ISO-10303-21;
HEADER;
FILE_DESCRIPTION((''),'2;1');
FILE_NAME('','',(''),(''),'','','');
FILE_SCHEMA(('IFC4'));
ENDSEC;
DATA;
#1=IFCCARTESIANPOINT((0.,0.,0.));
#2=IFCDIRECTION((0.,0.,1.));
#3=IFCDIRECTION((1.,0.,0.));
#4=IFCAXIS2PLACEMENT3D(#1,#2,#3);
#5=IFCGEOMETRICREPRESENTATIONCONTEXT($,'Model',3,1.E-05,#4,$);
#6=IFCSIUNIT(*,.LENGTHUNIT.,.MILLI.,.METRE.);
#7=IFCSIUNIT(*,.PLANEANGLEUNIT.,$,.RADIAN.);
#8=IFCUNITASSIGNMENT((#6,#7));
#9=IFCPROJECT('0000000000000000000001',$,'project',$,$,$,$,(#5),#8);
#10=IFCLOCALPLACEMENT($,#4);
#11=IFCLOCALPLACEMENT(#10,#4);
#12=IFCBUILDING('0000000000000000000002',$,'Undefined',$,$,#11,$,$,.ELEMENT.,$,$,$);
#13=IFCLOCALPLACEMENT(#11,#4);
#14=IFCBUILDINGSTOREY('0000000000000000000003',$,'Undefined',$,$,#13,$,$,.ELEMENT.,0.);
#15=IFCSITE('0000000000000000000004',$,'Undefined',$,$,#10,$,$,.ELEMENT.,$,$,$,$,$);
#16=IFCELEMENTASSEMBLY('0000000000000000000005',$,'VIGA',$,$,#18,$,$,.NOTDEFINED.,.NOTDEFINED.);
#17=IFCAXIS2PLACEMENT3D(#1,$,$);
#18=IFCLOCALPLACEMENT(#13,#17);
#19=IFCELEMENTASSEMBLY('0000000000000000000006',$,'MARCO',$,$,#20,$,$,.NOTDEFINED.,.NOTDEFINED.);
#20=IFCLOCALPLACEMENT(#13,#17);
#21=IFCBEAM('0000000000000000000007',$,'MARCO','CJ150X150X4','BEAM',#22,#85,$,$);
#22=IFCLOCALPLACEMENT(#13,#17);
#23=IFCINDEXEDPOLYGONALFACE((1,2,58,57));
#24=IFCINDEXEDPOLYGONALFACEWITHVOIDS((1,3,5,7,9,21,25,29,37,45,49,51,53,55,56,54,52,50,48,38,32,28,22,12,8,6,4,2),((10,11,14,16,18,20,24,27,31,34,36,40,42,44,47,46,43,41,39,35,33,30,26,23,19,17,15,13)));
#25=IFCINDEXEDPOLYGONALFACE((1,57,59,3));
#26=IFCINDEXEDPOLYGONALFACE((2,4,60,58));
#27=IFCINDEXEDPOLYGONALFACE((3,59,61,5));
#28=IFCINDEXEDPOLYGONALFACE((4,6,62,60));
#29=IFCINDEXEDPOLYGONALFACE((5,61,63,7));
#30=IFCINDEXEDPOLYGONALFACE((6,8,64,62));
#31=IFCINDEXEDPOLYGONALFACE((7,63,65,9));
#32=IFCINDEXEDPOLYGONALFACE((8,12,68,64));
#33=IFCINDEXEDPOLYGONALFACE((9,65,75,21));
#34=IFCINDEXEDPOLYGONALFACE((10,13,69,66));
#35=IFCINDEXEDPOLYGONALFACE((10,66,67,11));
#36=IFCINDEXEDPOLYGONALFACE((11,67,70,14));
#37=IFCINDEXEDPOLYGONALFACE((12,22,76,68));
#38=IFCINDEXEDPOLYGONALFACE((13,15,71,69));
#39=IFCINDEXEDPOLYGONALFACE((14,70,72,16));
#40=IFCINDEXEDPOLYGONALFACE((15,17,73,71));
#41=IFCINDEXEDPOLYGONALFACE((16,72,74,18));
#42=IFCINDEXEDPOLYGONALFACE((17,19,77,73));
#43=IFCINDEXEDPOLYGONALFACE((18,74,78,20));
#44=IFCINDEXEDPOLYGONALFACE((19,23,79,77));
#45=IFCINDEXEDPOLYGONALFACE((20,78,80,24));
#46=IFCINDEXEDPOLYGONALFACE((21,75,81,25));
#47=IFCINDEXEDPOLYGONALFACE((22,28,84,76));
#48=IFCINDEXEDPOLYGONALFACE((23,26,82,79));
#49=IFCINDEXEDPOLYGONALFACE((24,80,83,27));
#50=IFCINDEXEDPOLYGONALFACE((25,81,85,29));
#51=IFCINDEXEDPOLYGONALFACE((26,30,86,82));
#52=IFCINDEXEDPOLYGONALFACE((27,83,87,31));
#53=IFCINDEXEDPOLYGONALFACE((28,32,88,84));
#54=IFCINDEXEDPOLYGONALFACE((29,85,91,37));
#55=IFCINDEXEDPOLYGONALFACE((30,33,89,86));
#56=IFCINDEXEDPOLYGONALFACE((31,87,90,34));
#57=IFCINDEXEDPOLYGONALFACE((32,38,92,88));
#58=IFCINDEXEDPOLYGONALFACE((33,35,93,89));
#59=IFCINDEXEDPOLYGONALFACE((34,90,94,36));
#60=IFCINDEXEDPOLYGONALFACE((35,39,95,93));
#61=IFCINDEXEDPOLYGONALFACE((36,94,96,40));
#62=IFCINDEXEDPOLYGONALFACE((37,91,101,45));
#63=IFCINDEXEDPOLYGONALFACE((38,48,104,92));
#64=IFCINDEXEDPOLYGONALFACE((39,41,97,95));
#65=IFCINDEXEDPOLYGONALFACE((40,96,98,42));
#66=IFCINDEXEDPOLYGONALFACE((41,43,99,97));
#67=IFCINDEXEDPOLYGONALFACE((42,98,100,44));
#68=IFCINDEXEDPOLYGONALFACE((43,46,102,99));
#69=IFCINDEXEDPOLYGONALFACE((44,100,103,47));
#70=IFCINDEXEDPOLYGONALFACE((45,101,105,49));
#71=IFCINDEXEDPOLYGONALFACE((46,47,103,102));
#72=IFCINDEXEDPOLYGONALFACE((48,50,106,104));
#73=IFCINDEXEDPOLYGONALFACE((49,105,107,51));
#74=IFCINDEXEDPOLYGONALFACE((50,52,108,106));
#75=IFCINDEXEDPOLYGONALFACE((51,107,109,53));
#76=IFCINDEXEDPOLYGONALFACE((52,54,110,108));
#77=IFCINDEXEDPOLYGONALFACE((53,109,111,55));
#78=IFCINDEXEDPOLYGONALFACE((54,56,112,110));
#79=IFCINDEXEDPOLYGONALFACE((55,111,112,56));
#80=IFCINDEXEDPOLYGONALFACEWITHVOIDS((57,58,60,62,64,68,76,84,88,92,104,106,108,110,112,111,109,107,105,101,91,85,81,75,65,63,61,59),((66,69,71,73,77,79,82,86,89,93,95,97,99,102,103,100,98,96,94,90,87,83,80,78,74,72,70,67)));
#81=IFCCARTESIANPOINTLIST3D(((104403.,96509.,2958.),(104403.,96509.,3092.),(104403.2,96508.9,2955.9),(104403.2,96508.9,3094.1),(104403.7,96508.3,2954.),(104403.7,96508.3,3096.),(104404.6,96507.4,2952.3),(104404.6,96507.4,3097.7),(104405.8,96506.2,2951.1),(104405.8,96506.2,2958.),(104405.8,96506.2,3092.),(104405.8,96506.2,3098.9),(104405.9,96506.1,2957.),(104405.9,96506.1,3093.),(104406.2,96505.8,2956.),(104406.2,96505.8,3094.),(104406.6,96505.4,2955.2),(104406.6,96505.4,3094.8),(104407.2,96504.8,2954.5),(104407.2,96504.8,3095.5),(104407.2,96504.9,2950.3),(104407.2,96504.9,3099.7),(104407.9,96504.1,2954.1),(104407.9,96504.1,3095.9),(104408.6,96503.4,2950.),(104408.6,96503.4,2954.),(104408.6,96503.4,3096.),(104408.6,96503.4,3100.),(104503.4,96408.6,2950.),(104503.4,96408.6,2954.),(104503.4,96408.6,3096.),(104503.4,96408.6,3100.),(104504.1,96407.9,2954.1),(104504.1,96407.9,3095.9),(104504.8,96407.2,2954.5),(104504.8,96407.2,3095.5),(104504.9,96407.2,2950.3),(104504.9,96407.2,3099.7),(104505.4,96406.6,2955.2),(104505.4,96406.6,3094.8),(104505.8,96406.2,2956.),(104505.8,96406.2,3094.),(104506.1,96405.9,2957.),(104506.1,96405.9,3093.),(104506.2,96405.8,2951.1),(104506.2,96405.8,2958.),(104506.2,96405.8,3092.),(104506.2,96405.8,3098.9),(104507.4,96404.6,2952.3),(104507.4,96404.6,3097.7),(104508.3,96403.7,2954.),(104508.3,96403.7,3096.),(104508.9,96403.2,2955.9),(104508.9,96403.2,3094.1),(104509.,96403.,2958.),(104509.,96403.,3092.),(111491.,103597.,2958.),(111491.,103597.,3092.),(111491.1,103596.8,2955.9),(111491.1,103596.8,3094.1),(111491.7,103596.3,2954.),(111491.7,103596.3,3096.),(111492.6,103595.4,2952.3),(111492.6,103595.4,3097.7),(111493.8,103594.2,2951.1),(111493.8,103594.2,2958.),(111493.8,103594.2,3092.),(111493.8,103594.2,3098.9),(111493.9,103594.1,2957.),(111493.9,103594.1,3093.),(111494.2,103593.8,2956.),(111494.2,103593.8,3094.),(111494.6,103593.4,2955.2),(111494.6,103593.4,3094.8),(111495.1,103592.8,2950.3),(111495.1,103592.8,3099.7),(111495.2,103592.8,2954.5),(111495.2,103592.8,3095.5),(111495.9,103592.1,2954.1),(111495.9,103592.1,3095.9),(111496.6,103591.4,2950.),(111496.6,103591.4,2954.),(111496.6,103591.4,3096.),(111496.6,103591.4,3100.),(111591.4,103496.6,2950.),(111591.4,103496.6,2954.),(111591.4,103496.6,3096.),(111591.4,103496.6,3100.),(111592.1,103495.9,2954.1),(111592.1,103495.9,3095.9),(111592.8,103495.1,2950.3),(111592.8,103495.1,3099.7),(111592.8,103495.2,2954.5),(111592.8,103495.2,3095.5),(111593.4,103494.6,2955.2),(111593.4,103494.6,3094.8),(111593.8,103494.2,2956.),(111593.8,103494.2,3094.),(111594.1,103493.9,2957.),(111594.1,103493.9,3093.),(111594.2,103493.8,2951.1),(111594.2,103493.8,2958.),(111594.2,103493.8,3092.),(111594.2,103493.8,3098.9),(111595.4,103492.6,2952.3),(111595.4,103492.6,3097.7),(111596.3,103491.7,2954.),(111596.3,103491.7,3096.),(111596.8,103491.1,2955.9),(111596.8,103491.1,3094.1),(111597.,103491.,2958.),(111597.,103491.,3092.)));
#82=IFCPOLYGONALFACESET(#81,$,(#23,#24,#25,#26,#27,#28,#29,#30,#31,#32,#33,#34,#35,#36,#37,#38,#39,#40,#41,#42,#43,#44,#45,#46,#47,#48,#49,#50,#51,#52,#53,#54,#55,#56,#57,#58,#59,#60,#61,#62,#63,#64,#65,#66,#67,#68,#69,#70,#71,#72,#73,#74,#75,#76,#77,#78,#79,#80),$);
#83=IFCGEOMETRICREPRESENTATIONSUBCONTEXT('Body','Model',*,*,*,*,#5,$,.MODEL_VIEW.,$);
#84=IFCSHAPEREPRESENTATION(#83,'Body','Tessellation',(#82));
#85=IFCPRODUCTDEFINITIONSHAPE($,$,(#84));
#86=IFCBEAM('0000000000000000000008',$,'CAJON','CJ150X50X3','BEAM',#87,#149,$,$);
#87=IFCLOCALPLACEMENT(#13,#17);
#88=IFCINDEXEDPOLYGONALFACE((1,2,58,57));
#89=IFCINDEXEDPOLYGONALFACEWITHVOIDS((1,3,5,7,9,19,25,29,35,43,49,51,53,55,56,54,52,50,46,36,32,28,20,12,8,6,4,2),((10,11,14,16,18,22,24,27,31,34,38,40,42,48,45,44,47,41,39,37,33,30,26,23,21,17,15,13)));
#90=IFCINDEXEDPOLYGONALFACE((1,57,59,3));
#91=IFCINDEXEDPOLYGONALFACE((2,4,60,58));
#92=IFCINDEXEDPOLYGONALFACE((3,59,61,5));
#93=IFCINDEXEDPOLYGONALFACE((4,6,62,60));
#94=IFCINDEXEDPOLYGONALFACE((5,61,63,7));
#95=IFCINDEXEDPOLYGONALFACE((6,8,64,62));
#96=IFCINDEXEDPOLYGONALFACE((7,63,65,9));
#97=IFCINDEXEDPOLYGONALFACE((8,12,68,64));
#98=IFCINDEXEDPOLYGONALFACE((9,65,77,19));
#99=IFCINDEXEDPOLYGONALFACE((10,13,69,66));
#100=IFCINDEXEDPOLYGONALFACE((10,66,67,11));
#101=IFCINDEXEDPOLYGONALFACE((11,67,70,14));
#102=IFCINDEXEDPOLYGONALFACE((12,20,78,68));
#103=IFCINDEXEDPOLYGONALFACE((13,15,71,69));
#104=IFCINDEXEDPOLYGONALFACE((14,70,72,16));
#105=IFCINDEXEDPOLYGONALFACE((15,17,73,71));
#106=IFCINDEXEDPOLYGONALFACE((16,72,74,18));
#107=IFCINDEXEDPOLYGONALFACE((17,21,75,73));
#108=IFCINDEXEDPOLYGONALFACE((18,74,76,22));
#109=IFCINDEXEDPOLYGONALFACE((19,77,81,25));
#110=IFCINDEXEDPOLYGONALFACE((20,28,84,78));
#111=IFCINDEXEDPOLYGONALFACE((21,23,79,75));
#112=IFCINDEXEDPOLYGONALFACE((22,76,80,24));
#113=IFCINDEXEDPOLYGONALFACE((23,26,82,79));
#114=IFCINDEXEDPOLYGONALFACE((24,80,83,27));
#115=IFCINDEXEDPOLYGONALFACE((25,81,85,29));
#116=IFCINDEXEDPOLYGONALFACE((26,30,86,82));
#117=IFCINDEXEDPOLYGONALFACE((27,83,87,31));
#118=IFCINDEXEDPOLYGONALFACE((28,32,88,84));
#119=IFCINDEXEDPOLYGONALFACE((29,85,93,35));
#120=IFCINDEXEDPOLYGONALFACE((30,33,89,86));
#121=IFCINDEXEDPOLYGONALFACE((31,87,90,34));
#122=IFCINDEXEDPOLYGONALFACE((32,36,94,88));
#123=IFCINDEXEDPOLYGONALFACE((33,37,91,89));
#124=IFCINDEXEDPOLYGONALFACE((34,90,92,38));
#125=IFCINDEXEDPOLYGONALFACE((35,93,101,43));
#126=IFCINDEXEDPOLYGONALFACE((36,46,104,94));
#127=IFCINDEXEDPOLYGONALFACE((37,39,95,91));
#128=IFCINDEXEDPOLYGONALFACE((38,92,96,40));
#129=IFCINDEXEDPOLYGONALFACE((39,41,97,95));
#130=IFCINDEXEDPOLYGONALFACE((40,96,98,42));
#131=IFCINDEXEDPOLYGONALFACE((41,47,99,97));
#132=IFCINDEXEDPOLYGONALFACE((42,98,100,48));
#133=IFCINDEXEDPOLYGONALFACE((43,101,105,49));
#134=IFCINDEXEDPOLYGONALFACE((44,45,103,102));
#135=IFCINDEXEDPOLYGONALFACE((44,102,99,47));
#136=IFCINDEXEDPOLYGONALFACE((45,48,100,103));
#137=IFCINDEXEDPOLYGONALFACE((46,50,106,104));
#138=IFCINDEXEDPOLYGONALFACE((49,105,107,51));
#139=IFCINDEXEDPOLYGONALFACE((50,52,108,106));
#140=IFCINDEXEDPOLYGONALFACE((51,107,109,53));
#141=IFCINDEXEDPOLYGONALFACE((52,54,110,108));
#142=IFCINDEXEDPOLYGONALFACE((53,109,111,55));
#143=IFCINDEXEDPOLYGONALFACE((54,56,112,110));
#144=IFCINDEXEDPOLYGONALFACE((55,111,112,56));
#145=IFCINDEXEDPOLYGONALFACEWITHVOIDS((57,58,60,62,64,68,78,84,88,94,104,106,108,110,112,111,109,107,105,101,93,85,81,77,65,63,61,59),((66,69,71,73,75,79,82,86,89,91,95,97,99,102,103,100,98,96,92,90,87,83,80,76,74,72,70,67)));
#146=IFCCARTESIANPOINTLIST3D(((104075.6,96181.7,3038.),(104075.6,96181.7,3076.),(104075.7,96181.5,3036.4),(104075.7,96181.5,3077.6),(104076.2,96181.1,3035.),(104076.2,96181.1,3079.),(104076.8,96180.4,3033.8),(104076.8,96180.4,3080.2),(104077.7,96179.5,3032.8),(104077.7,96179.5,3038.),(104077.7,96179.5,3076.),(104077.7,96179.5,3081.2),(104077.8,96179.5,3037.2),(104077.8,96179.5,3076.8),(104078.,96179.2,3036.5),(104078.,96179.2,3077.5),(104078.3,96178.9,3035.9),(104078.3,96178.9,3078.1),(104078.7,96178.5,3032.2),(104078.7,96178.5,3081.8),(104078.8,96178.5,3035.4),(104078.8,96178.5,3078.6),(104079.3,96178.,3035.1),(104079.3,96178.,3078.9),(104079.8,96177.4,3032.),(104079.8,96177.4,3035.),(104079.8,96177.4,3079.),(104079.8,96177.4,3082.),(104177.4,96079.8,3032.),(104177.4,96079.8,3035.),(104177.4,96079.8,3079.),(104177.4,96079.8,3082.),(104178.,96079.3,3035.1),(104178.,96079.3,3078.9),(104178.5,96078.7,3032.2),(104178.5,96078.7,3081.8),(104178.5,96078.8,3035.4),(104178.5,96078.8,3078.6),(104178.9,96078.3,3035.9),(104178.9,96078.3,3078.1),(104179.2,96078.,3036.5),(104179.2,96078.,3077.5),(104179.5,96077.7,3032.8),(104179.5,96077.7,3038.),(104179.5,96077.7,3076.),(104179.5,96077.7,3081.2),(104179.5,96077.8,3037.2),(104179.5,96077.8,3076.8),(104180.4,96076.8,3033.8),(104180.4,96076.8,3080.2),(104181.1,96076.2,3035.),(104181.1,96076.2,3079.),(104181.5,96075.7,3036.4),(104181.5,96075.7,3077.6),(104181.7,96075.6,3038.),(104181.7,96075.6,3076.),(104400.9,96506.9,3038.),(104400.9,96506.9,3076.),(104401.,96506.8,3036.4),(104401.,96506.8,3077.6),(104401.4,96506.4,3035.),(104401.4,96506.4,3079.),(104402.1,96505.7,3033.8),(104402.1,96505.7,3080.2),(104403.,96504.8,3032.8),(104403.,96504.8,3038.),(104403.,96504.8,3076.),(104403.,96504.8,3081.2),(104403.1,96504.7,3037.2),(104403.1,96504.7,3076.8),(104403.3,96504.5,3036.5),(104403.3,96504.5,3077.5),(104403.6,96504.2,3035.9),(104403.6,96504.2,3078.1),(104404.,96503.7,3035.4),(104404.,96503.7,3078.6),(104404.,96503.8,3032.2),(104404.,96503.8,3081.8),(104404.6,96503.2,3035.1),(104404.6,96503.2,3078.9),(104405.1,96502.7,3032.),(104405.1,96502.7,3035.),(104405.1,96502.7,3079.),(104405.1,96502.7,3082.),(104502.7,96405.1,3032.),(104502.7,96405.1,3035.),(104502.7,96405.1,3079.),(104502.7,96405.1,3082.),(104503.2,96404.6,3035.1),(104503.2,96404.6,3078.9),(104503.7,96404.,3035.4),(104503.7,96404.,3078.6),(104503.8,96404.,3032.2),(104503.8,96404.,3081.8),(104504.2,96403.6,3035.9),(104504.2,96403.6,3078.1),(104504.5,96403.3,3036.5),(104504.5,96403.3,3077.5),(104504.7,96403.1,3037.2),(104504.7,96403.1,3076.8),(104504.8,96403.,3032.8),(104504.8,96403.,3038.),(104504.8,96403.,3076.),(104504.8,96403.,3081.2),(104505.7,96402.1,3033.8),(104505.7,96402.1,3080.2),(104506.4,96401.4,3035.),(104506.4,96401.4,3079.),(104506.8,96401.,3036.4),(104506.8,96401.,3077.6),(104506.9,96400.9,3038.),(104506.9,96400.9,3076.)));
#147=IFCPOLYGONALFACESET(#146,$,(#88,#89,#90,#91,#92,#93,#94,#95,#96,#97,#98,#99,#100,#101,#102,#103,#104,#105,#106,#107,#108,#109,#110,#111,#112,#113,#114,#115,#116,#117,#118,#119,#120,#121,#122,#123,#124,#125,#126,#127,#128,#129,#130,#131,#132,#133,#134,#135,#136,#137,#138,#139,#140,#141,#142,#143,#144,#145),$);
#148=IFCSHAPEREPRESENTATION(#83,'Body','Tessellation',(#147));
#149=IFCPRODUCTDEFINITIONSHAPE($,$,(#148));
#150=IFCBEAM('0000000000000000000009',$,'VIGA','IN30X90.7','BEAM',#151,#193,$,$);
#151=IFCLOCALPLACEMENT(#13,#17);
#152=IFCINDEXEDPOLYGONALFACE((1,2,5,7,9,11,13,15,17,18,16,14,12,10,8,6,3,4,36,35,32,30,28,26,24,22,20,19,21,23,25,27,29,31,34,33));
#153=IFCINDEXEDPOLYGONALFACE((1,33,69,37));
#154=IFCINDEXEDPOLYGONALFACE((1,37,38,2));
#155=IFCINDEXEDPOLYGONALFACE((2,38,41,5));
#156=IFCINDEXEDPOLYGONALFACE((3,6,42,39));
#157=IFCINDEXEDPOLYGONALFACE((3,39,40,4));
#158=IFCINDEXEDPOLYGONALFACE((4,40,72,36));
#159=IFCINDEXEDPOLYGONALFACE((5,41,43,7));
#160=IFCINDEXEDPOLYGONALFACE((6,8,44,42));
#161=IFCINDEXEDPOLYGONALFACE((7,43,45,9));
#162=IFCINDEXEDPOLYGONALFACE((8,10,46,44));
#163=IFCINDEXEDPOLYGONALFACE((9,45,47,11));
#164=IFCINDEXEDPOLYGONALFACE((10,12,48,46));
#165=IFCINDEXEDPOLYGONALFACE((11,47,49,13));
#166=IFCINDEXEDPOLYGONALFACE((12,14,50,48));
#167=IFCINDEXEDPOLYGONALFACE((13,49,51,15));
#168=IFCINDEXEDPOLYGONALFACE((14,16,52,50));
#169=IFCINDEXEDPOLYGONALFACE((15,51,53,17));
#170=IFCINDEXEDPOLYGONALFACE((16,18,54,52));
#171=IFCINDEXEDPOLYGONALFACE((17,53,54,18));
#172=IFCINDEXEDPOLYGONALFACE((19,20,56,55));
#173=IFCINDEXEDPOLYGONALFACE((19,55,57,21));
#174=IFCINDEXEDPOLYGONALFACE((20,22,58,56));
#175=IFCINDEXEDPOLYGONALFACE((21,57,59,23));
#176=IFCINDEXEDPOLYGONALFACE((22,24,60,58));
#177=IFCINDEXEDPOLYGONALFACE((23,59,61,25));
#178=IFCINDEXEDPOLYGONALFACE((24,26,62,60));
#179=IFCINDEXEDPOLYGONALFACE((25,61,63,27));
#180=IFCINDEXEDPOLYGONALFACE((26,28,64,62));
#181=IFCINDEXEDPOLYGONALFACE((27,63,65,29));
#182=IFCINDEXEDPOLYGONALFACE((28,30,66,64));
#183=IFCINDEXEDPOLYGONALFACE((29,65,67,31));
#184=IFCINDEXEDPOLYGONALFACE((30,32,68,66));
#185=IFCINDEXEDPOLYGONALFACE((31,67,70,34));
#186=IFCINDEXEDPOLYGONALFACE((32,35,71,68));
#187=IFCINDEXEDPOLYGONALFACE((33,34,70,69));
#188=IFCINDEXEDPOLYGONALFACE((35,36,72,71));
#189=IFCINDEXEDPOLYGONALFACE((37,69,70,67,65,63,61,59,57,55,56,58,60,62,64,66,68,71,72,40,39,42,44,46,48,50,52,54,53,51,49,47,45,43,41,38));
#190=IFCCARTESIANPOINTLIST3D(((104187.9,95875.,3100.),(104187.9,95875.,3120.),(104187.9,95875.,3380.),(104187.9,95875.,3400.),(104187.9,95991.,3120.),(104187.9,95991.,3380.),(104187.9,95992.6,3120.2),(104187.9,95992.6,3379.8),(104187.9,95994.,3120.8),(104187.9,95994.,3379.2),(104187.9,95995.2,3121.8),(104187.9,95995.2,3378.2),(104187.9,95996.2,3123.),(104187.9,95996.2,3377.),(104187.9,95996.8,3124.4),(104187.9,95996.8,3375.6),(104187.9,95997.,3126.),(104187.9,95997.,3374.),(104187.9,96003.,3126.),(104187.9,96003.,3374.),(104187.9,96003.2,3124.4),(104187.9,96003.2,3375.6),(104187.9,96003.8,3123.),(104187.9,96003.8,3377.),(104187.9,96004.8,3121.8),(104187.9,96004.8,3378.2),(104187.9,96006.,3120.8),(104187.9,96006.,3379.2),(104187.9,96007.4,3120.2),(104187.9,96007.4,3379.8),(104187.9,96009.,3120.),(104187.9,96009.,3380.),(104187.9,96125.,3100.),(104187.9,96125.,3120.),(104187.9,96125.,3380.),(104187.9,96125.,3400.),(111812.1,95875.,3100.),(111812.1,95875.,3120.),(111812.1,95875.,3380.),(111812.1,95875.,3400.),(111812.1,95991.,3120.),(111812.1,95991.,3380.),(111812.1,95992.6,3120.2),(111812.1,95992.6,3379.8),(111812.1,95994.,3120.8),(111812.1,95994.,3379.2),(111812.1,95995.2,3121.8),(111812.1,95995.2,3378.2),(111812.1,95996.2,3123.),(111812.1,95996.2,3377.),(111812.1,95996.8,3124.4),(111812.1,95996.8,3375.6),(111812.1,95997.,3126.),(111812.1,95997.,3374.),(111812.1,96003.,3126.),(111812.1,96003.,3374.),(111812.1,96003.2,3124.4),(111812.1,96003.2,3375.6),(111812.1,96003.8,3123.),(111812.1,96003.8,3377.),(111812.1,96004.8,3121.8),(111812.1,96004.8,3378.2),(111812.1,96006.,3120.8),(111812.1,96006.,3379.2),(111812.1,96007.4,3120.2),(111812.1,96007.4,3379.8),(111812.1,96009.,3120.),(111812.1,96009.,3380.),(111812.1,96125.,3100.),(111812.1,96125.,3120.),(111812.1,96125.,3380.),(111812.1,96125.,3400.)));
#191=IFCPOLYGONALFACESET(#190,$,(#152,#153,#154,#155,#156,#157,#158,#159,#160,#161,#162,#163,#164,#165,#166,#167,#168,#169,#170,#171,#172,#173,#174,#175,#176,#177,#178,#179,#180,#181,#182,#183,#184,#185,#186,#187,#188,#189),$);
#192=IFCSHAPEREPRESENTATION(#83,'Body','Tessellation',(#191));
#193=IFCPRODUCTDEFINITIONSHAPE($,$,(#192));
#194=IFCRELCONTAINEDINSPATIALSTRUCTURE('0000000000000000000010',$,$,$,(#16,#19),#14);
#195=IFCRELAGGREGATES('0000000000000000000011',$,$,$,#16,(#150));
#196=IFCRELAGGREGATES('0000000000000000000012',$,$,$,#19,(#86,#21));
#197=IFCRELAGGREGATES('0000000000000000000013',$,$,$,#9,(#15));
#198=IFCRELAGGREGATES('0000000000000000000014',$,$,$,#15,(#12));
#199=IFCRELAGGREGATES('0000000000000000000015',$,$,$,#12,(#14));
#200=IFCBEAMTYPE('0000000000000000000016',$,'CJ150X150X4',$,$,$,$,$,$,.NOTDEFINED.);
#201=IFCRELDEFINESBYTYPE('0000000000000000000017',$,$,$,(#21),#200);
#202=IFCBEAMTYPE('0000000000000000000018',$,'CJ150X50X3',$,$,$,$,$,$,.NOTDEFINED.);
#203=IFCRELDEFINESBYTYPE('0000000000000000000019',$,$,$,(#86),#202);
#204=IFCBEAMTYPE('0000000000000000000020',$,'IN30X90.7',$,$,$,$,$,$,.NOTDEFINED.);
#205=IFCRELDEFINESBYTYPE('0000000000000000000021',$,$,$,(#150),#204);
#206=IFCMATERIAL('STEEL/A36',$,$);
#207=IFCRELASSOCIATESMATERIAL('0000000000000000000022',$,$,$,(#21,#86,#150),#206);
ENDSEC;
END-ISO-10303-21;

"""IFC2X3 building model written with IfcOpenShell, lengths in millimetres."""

from ifc_helpers import new_model, si_unit, frame, origin_with_axes, origin_2d_with_axis, place, context, subcontext, project, spatial, hollow_rectangle, i_section, extrude, material, type_object, element, aggregate, save


model = new_model("IFC2X3")

# Units and contexts
model_context = context("Model", 3, precision=1e-05, world=origin_with_axes())
body_context = subcontext(model_context, "Body", "Model", "MODEL_VIEW")
ifc_project = project(units=[si_unit("LENGTHUNIT", "METRE", prefix="MILLI"), si_unit("PLANEANGLEUNIT", "RADIAN")], contexts=[model_context])

# Site, building, storey
site_placement = place(None, origin_with_axes())
site = spatial("IfcSite", under=ifc_project, at=site_placement, Name="Undefined", CompositionType="ELEMENT")
building_placement = place(site_placement, origin_with_axes())
building = spatial("IfcBuilding", under=site, at=building_placement, Name="Undefined", CompositionType="ELEMENT")
storey_placement = place(building_placement, origin_with_axes())
storey = spatial("IfcBuildingStorey", under=building, at=storey_placement, Name="Undefined", CompositionType="ELEMENT", Elevation=0.0)

# Element assembly
assembly_1_placement = place(storey_placement, origin_with_axes())
assembly_1 = element("IfcElementAssembly", 1, at=assembly_1_placement, inside=storey, Name="VIGA", AssemblyPlace="NOTDEFINED", PredefinedType="NOTDEFINED")
ifc_material_1 = material(Name="STEEL/A36")

# Element assembly, beams
assembly_2_placement = place(storey_placement, origin_with_axes())
assembly_2 = element("IfcElementAssembly", 2, at=assembly_2_placement, inside=storey, Name="MARCO", AssemblyPlace="NOTDEFINED", PredefinedType="NOTDEFINED")
beam_type_1 = type_object("IfcBeamType", Name="CJ150X150X4", PredefinedType="NOTDEFINED")
beam_1_placement = place(assembly_2_placement, frame((104456.0, 96456.0, 3025.0), z_axis=(0.0, 0.0, -1.0), x_axis=(0.707107, 0.707107, 0.0)))
beam_1 = element("IfcBeam", 3, at=beam_1_placement, type_object=beam_type_1, material=ifc_material_1, Name="MARCO", Description="CJ150X150X4", ObjectType="BEAM", context=body_context, shape_type="SweptSolid", body=[
    extrude(hollow_rectangle(XDim=150.0, YDim=150.0, WallThickness=4.0, InnerFilletRadius=4.0, OuterFilletRadius=8.0, at=origin_2d_with_axis()), frame((10023.9, 0.0, 0.0), z_axis=(-1.0, 0.0, 0.0), x_axis=(0.0, -1.0, 0.0)), (0.0, 0.0, 1.0), 10023.9),
])
beam_type_2 = type_object("IfcBeamType", Name="CJ150X50X3", PredefinedType="NOTDEFINED")
beam_2_placement = place(assembly_2_placement, frame((104453.9, 96453.9, 3057.0), z_axis=(-0.707107, 0.707107, 0.0), x_axis=(-0.707107, -0.707107, 0.0)))
beam_2 = element("IfcBeam", 4, at=beam_2_placement, type_object=beam_type_2, material=ifc_material_1, Name="CAJON", Description="CJ150X50X3", ObjectType="BEAM", context=body_context, shape_type="SweptSolid", body=[
    extrude(hollow_rectangle(XDim=50.0, YDim=150.0, WallThickness=3.0, InnerFilletRadius=3.0, OuterFilletRadius=6.0, at=origin_2d_with_axis()), frame((460.0, 0.0, 0.0), z_axis=(-1.0, 0.0, 0.0), x_axis=(0.0, -1.0, 0.0)), (0.0, 0.0, 1.0), 460.0),
])

# Beam
beam_type_3 = type_object("IfcBeamType", Name="IN30X90.7", PredefinedType="NOTDEFINED")
beam_3_placement = place(assembly_1_placement, frame((104187.9, 96000.0, 3250.0), z_axis=(0.0, 0.0, 1.0), x_axis=(1.0, 0.0, 0.0)))
beam_3 = element("IfcBeam", 5, at=beam_3_placement, type_object=beam_type_3, material=ifc_material_1, Name="VIGA", Description="IN30X90.7", ObjectType="BEAM", context=body_context, shape_type="SweptSolid", body=[
    extrude(i_section(OverallWidth=250.0, OverallDepth=300.0, WebThickness=6.0, FlangeThickness=20.0, FilletRadius=6.0, at=origin_2d_with_axis()), frame((7624.2, 0.0, 0.0), z_axis=(-1.0, 0.0, 0.0), x_axis=(0.0, -1.0, 0.0)), (0.0, 0.0, 1.0), 7624.2),
])
aggregate(assembly_1, [beam_3])

aggregate(assembly_2, [beam_2, beam_1])

save(model, "model.ifc")
